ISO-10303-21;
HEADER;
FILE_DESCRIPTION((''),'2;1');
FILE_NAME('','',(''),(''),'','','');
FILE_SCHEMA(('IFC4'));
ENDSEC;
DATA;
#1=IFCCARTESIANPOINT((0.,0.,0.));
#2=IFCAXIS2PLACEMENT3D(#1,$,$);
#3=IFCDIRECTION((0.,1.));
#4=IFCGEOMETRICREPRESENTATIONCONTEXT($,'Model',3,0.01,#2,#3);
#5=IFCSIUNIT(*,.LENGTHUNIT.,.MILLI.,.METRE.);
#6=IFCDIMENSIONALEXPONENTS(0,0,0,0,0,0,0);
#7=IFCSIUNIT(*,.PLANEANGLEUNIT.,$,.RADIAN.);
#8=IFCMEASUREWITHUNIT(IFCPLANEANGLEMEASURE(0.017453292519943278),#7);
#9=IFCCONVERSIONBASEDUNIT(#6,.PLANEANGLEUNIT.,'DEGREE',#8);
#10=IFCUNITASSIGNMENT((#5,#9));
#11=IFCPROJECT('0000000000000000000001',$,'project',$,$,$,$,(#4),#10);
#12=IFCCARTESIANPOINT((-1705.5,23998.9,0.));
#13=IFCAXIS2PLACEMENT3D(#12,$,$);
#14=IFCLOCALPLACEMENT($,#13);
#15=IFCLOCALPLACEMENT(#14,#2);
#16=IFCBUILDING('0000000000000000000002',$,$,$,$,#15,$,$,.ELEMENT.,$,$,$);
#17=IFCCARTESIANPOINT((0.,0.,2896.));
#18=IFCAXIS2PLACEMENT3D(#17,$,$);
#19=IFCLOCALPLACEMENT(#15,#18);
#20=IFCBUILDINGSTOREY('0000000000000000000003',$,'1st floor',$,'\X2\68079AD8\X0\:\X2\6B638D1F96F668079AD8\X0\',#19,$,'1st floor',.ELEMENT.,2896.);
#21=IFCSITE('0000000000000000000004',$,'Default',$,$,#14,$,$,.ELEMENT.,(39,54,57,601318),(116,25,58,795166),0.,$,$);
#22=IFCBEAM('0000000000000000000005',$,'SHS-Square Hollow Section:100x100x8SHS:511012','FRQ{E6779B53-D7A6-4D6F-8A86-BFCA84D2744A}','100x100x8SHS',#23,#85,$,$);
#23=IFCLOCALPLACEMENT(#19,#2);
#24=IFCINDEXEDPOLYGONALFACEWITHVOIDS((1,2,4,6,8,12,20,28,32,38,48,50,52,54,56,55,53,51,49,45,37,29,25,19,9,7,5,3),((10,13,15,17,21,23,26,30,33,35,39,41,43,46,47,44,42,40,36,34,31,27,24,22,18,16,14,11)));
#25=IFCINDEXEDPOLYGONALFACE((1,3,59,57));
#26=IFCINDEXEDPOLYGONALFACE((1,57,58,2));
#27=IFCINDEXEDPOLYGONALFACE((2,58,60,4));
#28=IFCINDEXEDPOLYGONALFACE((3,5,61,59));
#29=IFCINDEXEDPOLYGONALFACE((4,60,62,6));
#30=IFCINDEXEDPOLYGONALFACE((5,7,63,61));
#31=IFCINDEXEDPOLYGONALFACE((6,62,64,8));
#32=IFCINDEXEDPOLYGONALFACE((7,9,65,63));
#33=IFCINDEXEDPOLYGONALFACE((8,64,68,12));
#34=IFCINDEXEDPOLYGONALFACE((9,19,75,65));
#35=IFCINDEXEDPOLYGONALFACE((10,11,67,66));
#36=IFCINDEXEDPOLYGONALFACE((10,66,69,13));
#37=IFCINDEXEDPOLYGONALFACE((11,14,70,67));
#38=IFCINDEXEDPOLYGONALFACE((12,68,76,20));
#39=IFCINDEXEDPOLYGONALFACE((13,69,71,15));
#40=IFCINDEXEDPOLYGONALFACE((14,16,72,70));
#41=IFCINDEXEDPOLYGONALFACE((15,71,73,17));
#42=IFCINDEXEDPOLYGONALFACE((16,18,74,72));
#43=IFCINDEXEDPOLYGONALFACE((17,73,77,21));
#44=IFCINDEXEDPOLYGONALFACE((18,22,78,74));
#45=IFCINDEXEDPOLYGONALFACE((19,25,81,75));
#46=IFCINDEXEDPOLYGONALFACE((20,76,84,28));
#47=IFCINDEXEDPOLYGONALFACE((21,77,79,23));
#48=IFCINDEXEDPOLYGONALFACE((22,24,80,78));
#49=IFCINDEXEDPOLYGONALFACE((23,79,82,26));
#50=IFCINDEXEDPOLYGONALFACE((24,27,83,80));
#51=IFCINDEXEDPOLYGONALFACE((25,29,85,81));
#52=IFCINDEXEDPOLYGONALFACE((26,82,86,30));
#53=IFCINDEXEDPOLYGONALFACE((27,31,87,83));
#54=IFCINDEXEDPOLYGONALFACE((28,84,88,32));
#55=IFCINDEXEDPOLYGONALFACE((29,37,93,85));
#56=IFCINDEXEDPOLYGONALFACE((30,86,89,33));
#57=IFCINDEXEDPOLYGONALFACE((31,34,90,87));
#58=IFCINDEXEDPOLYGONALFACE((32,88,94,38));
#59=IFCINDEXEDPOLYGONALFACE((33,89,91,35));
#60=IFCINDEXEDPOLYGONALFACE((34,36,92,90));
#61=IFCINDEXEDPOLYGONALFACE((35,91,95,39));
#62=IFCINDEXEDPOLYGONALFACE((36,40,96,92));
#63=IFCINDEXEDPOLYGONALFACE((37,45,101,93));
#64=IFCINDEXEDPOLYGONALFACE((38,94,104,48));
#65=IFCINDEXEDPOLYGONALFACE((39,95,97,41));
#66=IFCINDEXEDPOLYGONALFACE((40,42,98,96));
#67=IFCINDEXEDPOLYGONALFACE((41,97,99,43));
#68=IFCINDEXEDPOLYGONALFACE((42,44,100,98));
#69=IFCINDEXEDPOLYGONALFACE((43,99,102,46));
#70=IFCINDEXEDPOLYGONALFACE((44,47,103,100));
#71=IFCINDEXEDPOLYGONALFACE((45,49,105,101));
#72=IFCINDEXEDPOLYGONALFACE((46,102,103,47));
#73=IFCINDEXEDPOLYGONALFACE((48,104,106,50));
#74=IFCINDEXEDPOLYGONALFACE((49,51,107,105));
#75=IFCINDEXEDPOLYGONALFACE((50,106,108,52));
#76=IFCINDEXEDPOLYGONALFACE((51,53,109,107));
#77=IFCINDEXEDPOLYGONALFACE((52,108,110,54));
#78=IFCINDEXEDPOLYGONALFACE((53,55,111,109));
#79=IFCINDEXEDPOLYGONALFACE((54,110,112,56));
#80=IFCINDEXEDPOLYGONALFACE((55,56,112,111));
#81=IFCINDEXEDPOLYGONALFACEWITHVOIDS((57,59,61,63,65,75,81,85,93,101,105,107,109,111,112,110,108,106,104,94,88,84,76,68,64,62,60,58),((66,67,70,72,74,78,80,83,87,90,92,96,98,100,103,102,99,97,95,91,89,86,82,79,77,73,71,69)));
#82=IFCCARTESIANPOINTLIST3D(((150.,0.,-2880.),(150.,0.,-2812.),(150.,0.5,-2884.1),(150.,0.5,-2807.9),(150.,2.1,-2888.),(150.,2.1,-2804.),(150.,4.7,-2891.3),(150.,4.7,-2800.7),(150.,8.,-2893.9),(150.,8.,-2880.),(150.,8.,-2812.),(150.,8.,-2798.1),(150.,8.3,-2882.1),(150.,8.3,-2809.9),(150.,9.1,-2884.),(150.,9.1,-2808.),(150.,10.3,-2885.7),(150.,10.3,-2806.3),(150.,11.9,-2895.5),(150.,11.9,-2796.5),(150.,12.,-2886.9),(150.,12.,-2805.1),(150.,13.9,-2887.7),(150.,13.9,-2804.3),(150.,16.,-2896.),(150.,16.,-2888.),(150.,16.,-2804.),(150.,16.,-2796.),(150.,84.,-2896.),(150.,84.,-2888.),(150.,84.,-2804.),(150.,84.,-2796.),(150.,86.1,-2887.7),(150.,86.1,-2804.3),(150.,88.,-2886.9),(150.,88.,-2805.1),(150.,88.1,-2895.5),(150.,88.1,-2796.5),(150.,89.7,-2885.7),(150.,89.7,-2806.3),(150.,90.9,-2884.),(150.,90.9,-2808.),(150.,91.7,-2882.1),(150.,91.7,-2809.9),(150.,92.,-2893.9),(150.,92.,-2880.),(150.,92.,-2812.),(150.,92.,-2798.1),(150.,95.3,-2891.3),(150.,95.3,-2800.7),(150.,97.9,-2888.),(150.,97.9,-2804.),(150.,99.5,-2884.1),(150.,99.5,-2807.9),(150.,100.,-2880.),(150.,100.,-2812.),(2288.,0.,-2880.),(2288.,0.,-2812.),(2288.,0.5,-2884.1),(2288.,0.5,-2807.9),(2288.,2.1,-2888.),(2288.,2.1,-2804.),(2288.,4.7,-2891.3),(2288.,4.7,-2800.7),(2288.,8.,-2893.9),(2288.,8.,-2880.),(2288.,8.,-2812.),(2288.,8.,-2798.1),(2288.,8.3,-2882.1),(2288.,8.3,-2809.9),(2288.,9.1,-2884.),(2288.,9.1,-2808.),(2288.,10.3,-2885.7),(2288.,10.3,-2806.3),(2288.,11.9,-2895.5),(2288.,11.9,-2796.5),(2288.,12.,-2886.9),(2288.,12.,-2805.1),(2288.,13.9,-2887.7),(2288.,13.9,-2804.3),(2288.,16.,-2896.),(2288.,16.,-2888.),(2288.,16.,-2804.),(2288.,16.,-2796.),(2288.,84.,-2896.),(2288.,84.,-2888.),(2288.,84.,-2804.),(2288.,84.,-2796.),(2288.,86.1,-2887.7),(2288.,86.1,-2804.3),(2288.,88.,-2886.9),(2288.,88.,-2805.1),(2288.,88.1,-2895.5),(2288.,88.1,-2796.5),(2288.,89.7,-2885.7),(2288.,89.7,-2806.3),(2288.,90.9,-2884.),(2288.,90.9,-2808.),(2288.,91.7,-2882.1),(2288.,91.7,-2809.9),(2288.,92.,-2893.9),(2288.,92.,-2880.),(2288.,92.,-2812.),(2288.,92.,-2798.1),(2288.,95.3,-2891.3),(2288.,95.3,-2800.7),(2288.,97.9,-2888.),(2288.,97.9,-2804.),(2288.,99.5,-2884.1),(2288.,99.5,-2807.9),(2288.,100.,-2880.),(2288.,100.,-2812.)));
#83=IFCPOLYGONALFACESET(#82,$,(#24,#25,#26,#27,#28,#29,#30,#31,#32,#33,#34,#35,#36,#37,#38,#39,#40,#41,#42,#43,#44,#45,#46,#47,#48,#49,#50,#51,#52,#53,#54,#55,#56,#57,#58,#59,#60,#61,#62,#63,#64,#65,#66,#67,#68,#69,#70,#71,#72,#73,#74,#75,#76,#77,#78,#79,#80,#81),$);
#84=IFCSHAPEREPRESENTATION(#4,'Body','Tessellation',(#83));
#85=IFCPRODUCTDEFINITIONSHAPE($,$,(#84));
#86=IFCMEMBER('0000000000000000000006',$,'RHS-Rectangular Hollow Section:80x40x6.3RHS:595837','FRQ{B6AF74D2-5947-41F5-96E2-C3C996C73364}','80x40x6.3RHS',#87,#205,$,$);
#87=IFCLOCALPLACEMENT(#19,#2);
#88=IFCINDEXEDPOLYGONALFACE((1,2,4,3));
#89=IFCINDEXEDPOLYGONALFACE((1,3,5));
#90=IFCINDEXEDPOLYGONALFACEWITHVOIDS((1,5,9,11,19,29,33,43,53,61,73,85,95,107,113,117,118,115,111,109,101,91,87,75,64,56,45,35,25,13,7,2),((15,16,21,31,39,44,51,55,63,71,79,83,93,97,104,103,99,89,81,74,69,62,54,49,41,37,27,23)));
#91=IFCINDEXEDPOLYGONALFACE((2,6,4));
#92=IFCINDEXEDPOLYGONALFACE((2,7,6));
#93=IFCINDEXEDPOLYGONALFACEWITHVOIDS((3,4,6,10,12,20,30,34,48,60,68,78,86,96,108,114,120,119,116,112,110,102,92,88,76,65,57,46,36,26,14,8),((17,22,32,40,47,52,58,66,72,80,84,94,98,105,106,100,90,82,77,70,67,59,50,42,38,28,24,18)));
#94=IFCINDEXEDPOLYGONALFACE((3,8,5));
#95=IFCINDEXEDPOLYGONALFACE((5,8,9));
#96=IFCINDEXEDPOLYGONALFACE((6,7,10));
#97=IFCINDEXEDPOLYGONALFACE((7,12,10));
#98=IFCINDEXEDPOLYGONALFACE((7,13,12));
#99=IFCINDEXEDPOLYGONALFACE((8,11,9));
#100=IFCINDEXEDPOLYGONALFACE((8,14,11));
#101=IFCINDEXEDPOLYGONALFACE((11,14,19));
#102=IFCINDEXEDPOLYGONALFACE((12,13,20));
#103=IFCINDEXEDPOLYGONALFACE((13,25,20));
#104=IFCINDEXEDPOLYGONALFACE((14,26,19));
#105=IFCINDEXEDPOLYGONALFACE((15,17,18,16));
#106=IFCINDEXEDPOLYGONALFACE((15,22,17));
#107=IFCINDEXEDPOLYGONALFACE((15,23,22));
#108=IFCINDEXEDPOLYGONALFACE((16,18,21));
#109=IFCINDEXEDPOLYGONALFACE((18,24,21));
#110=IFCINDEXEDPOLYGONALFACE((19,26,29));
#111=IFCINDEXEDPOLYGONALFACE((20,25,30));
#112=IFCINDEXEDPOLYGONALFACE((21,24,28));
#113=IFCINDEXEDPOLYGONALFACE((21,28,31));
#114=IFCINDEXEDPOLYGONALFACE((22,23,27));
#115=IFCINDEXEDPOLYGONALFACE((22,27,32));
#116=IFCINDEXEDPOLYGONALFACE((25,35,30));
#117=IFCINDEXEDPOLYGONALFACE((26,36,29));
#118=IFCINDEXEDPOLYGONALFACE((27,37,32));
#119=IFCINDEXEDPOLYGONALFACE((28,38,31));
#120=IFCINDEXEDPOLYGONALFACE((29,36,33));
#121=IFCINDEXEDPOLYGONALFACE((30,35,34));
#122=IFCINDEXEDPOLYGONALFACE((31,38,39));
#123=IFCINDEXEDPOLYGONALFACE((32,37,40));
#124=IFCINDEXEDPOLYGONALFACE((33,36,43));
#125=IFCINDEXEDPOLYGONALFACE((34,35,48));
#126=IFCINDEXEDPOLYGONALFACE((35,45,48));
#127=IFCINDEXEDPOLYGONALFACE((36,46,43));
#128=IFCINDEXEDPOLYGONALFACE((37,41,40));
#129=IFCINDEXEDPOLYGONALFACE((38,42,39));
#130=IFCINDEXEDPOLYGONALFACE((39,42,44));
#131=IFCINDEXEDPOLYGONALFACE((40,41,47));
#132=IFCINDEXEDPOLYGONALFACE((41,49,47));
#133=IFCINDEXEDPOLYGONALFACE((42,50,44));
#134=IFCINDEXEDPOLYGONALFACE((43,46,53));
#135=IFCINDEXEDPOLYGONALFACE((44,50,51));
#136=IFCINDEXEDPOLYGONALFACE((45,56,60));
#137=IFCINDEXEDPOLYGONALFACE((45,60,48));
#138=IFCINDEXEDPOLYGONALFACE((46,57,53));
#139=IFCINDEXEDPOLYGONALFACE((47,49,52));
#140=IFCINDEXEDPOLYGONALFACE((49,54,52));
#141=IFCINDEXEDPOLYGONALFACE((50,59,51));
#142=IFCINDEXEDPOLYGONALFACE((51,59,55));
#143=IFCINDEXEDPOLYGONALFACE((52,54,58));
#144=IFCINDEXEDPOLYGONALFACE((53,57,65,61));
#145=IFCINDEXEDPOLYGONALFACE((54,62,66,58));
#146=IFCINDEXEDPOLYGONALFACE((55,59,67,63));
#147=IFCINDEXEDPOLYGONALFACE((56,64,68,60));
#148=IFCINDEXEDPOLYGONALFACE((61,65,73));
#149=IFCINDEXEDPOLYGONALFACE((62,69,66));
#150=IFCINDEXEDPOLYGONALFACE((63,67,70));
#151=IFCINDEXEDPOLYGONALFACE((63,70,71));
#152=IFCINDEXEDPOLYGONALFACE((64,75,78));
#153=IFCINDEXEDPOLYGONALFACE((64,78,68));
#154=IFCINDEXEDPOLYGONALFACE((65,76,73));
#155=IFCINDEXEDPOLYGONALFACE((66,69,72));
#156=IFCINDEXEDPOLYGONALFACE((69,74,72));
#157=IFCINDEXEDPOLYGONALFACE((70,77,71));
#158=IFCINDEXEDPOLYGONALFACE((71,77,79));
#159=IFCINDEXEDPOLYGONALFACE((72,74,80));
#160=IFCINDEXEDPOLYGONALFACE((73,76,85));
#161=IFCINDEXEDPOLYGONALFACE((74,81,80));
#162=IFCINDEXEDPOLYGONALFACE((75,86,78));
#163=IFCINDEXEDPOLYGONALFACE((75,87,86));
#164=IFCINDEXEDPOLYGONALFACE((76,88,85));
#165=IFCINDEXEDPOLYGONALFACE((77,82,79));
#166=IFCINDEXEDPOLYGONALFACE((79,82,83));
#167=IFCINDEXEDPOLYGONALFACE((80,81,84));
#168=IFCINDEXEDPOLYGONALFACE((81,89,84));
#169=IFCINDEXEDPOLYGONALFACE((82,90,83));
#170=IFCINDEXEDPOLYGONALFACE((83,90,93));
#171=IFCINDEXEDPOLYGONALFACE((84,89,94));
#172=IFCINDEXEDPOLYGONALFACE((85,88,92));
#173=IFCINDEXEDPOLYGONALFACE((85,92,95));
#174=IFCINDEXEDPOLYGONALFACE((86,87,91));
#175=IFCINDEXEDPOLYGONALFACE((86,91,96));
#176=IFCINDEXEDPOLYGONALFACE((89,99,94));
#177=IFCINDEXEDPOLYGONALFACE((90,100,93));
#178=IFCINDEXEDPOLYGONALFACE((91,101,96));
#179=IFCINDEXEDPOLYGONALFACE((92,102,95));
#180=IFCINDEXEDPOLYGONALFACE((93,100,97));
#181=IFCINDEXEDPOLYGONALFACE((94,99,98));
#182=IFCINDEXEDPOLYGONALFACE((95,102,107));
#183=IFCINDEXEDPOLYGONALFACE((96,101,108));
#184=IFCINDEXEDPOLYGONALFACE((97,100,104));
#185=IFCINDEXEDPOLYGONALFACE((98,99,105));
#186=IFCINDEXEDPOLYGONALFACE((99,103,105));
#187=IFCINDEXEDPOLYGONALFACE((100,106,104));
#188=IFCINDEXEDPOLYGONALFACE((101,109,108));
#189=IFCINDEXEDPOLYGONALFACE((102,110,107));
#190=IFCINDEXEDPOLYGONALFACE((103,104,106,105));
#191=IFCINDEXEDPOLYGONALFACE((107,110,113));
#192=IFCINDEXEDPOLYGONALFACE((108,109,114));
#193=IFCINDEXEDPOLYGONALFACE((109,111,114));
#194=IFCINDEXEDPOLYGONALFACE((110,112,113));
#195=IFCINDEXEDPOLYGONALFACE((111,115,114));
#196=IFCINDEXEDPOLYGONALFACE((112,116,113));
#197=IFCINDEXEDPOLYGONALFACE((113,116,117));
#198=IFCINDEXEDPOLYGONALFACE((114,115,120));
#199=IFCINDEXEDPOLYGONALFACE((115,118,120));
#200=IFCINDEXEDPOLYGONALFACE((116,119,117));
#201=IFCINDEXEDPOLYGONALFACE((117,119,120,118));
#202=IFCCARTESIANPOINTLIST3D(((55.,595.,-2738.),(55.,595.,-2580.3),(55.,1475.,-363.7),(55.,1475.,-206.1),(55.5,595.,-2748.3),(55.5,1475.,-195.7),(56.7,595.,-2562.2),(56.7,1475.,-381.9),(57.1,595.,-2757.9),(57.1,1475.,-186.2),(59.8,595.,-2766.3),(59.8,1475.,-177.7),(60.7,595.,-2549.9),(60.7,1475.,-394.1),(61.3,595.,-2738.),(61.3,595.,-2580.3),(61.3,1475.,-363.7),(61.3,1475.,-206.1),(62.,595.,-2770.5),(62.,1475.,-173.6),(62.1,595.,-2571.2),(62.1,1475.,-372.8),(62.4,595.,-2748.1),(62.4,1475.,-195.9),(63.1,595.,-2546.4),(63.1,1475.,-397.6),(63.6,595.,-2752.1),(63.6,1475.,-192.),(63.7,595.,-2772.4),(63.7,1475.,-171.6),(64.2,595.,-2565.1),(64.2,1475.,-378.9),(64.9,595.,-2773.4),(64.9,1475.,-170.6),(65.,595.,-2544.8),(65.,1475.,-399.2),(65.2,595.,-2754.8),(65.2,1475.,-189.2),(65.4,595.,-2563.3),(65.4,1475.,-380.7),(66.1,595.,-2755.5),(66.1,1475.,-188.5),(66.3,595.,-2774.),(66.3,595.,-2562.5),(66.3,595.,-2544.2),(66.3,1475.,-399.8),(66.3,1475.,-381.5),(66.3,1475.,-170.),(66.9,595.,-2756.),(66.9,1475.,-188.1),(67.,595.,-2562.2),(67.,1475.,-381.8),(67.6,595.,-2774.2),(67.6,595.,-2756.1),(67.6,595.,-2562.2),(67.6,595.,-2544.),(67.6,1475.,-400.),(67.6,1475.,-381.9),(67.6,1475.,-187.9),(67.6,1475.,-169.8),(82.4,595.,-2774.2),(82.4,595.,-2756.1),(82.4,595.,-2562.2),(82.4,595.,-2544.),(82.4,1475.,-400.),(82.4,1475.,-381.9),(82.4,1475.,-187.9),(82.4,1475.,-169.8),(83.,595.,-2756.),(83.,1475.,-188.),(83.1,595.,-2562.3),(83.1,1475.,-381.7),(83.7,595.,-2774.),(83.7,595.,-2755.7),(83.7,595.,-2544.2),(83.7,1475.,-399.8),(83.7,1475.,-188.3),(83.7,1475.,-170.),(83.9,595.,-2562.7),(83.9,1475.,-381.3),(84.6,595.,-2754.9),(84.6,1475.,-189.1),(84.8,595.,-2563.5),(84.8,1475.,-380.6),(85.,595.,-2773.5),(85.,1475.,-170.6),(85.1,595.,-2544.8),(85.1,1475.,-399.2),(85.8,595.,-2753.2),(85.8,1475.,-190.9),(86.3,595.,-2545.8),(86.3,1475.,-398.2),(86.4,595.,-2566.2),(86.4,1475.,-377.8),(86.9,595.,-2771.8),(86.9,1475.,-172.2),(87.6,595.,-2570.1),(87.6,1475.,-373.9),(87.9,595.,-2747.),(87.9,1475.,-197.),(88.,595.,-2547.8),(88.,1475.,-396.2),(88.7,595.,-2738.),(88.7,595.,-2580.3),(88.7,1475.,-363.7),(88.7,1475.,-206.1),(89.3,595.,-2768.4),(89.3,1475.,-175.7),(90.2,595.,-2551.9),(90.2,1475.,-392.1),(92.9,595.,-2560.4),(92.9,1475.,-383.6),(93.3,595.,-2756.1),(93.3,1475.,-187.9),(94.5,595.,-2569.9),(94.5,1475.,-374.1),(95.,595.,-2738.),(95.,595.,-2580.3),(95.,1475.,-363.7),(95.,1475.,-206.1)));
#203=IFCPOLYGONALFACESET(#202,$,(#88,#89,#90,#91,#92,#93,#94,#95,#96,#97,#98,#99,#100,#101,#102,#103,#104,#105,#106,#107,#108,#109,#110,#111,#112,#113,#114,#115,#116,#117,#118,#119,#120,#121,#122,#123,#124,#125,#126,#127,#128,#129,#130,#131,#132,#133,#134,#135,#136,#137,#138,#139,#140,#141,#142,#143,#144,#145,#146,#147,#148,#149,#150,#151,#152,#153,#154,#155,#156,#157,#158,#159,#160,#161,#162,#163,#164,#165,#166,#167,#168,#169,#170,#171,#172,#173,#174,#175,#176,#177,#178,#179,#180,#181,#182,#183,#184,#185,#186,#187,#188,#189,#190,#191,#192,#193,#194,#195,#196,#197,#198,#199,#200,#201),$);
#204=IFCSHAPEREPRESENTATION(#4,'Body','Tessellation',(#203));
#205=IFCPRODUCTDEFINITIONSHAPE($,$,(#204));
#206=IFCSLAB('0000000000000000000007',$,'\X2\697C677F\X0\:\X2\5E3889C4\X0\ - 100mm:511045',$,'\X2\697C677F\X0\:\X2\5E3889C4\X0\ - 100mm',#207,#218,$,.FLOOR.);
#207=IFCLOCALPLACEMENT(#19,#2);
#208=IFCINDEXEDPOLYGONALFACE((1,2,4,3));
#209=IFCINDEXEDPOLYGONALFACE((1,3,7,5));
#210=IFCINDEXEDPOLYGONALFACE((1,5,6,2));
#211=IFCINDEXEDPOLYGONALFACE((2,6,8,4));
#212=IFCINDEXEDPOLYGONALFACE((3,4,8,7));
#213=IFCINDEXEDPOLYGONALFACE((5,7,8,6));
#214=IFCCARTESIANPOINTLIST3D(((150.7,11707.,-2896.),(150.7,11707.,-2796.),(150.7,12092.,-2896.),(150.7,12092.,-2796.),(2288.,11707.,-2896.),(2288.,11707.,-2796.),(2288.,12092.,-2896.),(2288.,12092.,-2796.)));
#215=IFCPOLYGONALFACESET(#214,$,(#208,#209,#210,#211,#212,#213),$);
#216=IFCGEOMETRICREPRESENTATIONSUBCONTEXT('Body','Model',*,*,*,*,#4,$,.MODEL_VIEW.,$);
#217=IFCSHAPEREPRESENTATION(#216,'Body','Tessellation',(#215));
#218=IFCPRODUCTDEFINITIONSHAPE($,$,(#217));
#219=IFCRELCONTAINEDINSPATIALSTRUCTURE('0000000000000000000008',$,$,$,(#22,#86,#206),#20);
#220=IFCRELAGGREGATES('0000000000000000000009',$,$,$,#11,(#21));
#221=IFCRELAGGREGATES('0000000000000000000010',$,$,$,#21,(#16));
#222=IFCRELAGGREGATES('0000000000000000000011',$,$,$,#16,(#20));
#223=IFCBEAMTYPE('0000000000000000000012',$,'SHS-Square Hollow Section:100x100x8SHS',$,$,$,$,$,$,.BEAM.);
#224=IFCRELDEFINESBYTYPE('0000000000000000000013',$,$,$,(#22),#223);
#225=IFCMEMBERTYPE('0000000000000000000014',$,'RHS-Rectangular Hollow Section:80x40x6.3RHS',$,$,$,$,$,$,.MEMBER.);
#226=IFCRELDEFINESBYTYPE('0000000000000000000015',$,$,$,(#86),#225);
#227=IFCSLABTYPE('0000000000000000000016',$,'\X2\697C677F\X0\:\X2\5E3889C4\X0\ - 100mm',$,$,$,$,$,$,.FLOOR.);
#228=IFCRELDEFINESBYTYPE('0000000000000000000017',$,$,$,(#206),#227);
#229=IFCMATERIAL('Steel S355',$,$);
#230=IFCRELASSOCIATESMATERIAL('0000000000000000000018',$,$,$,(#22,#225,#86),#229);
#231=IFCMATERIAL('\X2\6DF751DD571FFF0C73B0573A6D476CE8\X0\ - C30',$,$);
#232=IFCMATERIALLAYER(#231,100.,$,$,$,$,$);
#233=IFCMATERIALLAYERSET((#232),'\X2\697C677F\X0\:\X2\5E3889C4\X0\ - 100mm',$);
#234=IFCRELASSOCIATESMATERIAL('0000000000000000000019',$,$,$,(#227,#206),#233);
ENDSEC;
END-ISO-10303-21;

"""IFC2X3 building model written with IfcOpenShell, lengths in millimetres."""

from ifc_helpers import new_model, entity, si_unit, converted_unit, direction, frame, origin, origin_2d, origin_2d_with_axis, place, context, subcontext, project, spatial, rectangle, hollow_rectangle, extrude, clip, halfspace, material, layer, layer_set, layer_usage, type_object, element, save


model = new_model("IFC2X3")

# Units and contexts
model_context = context("Model", 3, precision=0.01, world=origin(), true_north=direction((0.0, 1.0)))
body_context = subcontext(model_context, "Body", "Model", "MODEL_VIEW")
ifc_project = project(units=[si_unit("LENGTHUNIT", "METRE", prefix="MILLI"), converted_unit("PLANEANGLEUNIT", "DEGREE", entity("IfcPlaneAngleMeasure", 0.017453292519943278), si_unit("PLANEANGLEUNIT", "RADIAN"), dimensions=[0, 0, 0, 0, 0, 0, 0])], contexts=[model_context])

# Site, building, storey
site_placement = place(None, frame((-1705.5, 23998.9, 0.0)))
site = spatial("IfcSite", under=ifc_project, at=site_placement, Name="Default", CompositionType="ELEMENT", RefLatitude=(39, 54, 57, 601318), RefLongitude=(116, 25, 58, 795166), RefElevation=0.0)
building_placement = place(site_placement, origin())
building = spatial("IfcBuilding", under=site, at=building_placement, CompositionType="ELEMENT")
storey_placement = place(building_placement, frame((0.0, 0.0, 2896.0)))
storey = spatial("IfcBuildingStorey", under=building, at=storey_placement, Name="1st floor", ObjectType="标高:正负零标高", LongName="1st floor", CompositionType="ELEMENT", Elevation=2896.0)

# Shared definitions
ifc_material_1 = material(Name="Steel S355")

# Beam
beam_type_1 = type_object("IfcBeamType", Name="SHS-Square Hollow Section:100x100x8SHS", PredefinedType="BEAM")
beam_1_placement = place(storey_placement, frame((-57.7, 50.0, -2846.0), z_axis=(-1.0, 0.0, 0.0), x_axis=(0.0, -1.0, 0.0)))
element("IfcBeam", 1, at=beam_1_placement, inside=storey, type_object=beam_type_1, material=ifc_material_1, Name="SHS-Square Hollow Section:100x100x8SHS:511012", Description="FRQ{E6779B53-D7A6-4D6F-8A86-BFCA84D2744A}", ObjectType="100x100x8SHS", context=model_context, shape_type="Clipping", body=[
    clip(clip(extrude(hollow_rectangle(XDim=100.0, YDim=100.0, WallThickness=8.0, InnerFilletRadius=8.0, OuterFilletRadius=16.0, at=origin_2d()), origin(), (0.0, 0.0, -1.0), 2551.4), halfspace(frame((50.0, -50.0, -2345.7), z_axis=(0.0, 0.0, 1.0), x_axis=(1.0, 0.0, 0.0)), True)), halfspace(frame((50.0, -50.0, -207.7), z_axis=(0.0, 0.0, -1.0), x_axis=(-1.0, 0.0, 0.0)), True)),
])

# Member
member_type = type_object("IfcMemberType", Name="RHS-Rectangular Hollow Section:80x40x6.3RHS", PredefinedType="MEMBER", material=ifc_material_1)
member_1_placement = place(storey_placement, frame((75.0, 490.3, -2941.7), z_axis=(0.0, -0.347543, -0.937664), x_axis=(1.0, 0.0, 0.0)))
element("IfcMember", 2, at=member_1_placement, inside=storey, type_object=member_type, material=ifc_material_1, Name="RHS-Rectangular Hollow Section:80x40x6.3RHS:595837", Description="FRQ{B6AF74D2-5947-41F5-96E2-C3C996C73364}", ObjectType="80x40x6.3RHS", context=model_context, shape_type="Clipping", body=[
    clip(clip(extrude(hollow_rectangle(XDim=40.0, YDim=80.0, WallThickness=6.3, InnerFilletRadius=6.3, OuterFilletRadius=12.6, at=origin_2d()), origin(), (0.0, 0.0, -1.0), 3105.9), halfspace(frame((-75.0, -82.3, -79.2), z_axis=(0.0, -0.937664, -0.347543), x_axis=(-1.0, 0.0, 0.0)), True)), halfspace(frame((-75.0, -907.5, -385.0), z_axis=(0.0, 0.937664, 0.347543), x_axis=(1.0, 0.0, 0.0)), True)),
])

# Slab
ifc_material_2 = material(Name="混凝土，现场浇注 - C30")
ifc_layer_1 = layer(ifc_material_2, 100.0)
ifc_layer_set_1 = layer_set([ifc_layer_1], Name="楼板:常规 - 100mm")
ifc_layer_usage_1 = layer_usage(ifc_layer_set_1, "AXIS3", "POSITIVE", 0.0)
slab_type = type_object("IfcSlabType", Name="楼板:常规 - 100mm", PredefinedType="FLOOR", material=ifc_layer_set_1)
slab_1_placement = place(storey_placement, origin())
element("IfcSlab", 3, at=slab_1_placement, inside=storey, type_object=slab_type, material=ifc_layer_usage_1, Name="楼板:常规 - 100mm:511045", ObjectType="楼板:常规 - 100mm", PredefinedType="FLOOR", context=body_context, shape_type="SweptSolid", body=[
    extrude(rectangle(XDim=385.0, YDim=2137.3, at=origin_2d_with_axis()), frame((1219.3, 11899.5, -2796.0), z_axis=(0.0, 0.0, -1.0), x_axis=(0.0, 1.0, 0.0)), (0.0, 0.0, 1.0), 100.0),
])

save(model, "model.ifc")
